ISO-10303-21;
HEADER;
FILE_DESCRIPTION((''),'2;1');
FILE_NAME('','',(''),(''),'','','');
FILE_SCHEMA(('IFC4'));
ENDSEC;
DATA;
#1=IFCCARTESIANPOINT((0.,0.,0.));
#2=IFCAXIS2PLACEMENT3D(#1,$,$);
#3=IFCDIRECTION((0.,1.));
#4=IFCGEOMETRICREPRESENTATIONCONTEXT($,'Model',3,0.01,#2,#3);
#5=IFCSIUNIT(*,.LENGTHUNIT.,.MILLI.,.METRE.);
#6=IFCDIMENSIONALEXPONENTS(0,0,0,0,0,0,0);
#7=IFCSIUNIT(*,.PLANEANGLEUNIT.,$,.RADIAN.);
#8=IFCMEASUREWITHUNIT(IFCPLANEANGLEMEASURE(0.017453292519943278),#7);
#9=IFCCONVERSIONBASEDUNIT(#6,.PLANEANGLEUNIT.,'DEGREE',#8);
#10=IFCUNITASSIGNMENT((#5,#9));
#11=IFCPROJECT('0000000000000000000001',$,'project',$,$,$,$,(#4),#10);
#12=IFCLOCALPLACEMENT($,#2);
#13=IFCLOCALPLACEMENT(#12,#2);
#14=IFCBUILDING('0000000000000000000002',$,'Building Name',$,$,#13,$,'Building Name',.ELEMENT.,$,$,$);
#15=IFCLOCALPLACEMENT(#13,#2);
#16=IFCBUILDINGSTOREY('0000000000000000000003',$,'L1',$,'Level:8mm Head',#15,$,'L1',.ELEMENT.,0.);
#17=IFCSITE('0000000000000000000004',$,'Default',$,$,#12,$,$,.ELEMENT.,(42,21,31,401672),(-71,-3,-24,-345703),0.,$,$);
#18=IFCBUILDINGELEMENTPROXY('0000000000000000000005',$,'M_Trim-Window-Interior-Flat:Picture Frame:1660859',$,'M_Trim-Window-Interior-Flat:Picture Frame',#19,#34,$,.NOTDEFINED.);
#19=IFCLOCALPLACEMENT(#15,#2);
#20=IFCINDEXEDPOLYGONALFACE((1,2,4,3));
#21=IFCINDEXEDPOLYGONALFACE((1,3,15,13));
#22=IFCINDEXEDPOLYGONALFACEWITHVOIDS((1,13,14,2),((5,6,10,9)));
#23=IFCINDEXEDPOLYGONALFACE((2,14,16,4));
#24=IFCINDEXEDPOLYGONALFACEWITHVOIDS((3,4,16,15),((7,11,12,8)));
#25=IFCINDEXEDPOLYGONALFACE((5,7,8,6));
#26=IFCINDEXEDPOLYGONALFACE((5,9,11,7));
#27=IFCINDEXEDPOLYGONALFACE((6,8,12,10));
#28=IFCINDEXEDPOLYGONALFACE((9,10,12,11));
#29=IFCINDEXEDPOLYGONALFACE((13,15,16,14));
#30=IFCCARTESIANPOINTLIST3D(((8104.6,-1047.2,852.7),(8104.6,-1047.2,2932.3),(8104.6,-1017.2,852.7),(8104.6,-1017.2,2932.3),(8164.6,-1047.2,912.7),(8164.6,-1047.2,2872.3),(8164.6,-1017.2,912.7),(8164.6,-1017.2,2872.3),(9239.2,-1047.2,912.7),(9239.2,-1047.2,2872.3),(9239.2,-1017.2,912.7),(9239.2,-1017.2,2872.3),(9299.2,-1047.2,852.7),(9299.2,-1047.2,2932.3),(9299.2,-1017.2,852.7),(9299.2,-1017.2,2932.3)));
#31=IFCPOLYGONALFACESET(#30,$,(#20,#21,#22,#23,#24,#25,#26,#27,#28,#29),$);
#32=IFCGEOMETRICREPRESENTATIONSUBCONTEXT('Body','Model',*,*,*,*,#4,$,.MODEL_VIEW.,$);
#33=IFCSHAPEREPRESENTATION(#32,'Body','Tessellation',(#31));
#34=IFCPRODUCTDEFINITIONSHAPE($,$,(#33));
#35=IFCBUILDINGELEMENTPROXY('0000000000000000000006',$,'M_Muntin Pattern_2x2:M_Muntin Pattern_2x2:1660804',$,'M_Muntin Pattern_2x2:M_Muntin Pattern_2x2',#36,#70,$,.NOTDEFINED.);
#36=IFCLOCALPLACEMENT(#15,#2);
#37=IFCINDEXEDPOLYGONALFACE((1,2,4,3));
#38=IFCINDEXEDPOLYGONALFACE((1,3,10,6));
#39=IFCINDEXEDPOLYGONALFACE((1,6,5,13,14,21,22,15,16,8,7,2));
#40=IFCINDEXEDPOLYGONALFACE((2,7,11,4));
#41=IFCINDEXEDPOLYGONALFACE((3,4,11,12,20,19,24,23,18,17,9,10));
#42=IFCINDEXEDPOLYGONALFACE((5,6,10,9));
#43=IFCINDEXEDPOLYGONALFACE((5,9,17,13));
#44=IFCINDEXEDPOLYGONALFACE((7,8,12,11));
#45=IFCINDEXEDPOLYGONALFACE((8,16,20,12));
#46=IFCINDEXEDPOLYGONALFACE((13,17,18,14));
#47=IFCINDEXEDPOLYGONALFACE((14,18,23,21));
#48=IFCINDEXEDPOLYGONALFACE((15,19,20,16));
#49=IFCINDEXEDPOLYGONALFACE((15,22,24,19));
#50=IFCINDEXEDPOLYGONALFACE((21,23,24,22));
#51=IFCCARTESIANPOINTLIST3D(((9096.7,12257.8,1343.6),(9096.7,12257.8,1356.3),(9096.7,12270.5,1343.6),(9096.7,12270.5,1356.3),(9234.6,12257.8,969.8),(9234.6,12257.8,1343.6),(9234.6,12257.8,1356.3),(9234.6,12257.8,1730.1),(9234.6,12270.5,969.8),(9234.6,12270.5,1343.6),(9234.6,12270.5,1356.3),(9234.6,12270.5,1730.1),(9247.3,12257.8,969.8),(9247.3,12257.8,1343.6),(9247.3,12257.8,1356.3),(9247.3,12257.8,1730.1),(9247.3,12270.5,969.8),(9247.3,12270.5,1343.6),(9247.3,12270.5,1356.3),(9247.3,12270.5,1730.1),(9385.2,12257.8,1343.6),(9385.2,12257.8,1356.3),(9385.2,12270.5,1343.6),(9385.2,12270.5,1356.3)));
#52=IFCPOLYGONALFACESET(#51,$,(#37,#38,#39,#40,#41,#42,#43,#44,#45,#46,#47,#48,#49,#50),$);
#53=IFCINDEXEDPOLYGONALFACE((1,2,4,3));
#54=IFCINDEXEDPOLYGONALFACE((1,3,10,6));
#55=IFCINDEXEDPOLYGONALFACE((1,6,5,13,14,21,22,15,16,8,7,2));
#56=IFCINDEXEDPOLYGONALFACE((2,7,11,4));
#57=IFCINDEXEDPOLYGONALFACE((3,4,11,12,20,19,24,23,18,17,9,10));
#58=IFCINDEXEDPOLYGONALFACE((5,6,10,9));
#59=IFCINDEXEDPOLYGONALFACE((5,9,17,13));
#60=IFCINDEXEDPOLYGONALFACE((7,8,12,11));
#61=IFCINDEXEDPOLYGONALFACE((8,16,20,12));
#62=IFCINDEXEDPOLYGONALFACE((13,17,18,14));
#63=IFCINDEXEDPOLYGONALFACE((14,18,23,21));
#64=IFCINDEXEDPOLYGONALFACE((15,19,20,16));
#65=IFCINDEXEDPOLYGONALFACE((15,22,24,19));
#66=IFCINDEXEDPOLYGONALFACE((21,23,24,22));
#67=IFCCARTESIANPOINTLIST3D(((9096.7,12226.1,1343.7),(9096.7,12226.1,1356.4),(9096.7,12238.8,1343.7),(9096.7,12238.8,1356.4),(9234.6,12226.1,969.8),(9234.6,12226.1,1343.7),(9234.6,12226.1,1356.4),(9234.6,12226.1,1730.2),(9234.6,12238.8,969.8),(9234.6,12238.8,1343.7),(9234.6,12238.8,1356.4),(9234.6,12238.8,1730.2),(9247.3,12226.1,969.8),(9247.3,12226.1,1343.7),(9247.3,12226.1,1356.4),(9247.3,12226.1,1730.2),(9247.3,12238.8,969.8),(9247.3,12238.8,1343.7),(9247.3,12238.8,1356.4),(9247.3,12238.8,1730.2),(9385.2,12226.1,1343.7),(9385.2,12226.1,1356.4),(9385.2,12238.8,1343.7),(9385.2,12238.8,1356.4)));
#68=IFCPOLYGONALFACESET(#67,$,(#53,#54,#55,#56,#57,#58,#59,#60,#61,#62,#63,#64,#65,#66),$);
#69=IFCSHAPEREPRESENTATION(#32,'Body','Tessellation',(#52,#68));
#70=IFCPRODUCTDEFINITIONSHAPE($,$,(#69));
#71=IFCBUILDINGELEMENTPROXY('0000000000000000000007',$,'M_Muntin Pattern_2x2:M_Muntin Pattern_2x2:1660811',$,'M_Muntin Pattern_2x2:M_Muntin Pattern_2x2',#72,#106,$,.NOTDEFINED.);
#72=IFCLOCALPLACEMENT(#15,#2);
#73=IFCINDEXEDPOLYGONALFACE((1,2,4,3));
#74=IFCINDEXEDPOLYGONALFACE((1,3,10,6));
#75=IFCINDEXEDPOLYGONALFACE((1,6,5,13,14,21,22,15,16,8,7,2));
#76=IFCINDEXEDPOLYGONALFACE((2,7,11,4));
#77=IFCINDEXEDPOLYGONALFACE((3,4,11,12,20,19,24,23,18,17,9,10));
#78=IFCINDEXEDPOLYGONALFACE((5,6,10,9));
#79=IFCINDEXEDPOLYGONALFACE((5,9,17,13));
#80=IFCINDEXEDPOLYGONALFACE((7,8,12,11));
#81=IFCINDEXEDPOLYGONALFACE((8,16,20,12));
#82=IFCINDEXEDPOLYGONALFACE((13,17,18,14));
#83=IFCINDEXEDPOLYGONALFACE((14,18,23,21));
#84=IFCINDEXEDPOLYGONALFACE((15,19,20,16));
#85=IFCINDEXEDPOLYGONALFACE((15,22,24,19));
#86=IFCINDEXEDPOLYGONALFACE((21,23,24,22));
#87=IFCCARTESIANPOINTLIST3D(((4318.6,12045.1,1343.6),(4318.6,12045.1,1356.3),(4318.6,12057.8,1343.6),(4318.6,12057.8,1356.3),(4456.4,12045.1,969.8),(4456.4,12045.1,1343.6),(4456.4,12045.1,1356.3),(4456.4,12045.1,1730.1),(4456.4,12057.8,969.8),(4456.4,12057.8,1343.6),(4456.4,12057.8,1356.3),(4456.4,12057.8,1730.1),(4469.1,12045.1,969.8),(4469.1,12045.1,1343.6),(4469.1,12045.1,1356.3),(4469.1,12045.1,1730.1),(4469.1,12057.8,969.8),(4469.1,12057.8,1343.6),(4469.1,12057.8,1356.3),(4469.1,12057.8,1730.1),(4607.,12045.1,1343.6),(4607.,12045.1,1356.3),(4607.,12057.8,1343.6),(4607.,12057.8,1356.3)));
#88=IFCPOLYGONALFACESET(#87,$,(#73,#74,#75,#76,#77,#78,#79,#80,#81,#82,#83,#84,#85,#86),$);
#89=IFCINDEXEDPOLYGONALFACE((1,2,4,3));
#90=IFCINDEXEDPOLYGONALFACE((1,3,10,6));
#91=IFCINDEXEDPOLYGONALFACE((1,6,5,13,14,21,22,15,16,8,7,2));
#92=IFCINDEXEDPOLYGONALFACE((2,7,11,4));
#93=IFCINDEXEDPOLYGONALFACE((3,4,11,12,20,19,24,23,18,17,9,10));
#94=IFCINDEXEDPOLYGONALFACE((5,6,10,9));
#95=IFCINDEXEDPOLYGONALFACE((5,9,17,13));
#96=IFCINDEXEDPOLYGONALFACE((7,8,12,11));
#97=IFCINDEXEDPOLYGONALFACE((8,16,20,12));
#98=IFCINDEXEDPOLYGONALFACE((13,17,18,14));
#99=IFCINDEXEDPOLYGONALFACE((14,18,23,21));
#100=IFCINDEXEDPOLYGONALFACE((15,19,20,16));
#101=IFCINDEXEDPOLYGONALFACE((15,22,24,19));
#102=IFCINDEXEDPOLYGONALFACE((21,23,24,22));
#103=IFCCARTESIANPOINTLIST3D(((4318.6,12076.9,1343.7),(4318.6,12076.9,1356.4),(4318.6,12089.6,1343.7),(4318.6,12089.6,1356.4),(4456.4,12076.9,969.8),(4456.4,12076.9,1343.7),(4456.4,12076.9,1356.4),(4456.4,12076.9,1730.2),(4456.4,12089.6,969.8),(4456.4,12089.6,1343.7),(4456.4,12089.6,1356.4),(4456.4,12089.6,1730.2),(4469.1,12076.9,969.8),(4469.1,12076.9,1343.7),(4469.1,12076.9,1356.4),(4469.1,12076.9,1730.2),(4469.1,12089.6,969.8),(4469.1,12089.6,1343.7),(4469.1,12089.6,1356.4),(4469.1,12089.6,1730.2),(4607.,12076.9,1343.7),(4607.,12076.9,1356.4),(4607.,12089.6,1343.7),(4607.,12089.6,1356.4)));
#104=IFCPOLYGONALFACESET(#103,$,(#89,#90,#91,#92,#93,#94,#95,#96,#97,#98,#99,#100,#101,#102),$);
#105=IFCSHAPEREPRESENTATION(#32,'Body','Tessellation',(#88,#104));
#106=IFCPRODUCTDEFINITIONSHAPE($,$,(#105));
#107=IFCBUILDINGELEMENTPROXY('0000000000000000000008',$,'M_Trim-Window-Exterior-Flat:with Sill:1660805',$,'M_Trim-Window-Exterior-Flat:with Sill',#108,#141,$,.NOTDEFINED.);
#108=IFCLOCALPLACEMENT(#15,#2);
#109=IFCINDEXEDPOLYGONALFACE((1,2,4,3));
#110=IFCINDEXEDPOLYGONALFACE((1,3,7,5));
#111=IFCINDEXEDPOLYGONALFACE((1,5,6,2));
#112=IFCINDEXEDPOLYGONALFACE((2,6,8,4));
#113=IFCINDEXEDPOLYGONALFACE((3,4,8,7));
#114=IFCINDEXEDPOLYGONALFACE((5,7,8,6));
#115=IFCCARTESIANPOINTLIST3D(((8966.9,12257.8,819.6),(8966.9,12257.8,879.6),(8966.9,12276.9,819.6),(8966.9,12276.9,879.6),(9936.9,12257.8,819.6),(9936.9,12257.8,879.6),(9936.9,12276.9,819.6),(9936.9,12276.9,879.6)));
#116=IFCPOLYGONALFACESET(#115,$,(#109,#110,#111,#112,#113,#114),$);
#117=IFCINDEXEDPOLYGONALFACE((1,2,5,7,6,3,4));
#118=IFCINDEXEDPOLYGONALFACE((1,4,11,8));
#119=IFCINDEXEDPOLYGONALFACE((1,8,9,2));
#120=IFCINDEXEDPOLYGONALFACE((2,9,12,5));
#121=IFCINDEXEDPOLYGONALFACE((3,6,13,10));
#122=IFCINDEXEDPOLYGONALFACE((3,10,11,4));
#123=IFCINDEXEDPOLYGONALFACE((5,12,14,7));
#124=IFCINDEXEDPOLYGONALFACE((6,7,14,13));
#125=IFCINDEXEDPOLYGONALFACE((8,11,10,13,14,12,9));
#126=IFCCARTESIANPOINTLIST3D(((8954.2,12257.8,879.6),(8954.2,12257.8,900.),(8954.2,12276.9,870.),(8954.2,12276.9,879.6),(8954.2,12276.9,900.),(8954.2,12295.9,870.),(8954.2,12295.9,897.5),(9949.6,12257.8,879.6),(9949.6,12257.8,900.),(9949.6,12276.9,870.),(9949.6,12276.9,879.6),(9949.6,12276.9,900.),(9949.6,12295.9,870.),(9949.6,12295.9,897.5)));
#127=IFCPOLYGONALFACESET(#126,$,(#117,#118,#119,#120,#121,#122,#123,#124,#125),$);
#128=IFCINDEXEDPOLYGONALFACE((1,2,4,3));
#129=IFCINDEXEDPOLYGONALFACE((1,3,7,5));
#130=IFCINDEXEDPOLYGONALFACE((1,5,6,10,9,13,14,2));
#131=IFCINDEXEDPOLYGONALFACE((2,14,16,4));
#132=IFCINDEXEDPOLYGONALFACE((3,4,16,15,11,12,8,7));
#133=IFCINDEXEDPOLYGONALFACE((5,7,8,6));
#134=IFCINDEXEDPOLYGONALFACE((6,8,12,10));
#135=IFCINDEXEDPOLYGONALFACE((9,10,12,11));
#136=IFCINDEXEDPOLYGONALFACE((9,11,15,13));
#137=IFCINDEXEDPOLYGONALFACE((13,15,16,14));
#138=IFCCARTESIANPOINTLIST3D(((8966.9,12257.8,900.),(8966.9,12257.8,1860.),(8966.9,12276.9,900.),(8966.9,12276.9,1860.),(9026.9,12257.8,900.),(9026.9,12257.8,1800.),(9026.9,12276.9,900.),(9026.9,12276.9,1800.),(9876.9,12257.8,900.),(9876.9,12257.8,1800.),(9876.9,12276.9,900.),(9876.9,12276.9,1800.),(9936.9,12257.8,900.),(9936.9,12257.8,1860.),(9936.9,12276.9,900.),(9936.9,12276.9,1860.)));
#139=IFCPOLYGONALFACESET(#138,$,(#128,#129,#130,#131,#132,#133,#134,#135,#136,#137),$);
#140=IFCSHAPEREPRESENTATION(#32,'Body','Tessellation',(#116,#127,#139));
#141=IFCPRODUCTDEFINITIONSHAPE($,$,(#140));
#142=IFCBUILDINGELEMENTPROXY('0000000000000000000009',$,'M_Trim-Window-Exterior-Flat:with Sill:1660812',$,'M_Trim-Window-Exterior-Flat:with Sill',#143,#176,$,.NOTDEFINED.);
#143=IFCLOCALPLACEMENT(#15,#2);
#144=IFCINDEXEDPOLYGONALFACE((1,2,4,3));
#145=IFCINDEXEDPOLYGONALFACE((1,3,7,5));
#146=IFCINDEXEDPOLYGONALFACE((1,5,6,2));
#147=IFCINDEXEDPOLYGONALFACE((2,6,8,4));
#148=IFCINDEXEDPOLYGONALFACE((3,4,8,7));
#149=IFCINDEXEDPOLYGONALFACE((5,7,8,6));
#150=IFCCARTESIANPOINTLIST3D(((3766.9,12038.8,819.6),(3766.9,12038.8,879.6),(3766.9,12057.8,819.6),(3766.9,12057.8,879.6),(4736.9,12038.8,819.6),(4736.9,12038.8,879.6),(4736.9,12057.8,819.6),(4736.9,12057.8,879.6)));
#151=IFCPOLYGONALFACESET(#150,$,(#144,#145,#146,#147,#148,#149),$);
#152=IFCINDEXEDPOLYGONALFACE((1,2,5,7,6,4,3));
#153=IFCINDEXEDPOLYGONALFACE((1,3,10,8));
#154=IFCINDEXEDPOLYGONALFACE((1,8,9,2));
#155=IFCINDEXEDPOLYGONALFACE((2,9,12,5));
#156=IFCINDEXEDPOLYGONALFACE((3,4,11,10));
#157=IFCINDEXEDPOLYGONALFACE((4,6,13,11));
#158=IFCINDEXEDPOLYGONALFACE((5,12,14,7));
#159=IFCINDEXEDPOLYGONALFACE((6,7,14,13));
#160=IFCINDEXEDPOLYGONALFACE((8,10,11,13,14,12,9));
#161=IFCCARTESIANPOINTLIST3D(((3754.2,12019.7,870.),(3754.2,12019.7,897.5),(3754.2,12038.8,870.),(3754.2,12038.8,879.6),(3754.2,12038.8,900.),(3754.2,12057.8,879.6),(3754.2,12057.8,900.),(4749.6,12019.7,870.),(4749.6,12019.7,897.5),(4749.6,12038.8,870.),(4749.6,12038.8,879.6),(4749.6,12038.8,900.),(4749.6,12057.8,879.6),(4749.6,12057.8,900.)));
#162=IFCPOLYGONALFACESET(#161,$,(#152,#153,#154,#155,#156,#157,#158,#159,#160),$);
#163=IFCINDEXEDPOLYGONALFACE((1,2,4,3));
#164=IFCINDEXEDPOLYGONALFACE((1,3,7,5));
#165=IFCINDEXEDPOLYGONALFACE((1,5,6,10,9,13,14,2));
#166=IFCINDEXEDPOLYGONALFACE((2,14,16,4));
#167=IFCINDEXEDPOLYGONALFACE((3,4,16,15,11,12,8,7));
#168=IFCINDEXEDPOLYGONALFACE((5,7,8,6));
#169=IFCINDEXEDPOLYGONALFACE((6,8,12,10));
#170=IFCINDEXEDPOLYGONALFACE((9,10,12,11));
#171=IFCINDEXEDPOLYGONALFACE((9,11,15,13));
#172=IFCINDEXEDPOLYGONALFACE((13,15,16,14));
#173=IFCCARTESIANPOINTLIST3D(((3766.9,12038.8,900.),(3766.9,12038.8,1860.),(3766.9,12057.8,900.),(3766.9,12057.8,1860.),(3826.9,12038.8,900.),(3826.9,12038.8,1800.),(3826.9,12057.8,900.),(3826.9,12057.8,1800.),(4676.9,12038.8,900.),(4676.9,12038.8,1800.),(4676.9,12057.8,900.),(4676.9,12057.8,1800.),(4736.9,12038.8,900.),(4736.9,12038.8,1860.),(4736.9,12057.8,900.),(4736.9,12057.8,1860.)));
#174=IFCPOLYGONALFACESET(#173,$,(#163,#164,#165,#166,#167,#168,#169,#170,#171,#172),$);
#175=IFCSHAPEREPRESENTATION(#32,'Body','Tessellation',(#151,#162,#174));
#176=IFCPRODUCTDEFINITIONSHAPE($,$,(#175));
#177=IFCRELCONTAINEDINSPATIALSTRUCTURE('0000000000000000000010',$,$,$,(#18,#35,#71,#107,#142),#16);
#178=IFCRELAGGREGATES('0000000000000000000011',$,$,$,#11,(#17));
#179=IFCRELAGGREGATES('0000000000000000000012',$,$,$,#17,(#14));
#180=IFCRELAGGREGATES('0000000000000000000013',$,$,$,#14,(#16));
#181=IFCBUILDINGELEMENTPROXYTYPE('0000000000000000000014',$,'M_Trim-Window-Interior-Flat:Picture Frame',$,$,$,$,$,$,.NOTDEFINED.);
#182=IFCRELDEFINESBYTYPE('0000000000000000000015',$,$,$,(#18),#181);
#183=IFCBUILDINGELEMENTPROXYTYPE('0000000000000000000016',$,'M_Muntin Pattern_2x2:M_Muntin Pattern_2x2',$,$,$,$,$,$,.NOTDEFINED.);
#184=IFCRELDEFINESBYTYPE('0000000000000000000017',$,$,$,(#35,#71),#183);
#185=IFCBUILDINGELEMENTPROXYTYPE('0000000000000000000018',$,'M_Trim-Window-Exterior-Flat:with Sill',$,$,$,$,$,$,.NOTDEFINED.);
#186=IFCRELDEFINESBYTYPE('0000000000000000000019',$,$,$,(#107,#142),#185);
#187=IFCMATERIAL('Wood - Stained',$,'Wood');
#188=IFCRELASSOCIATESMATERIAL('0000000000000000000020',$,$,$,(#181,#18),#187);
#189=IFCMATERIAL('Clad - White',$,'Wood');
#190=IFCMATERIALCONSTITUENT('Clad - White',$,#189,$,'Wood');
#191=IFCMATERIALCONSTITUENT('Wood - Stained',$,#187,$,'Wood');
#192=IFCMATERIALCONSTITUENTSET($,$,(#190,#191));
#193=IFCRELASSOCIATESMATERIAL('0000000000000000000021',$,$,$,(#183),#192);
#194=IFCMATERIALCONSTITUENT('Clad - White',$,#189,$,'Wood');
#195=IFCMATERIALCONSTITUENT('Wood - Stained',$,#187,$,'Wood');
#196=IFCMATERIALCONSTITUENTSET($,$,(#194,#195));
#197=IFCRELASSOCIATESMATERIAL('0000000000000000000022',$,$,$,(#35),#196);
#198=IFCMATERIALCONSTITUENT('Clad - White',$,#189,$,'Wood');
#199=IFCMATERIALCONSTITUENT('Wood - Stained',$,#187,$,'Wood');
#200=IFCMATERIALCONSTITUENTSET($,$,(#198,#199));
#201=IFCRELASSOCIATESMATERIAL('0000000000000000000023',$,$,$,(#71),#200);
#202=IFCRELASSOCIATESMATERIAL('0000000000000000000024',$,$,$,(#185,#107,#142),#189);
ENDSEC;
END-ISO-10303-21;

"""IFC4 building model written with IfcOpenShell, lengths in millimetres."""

from ifc_helpers import new_model, entity, si_unit, converted_unit, direction, frame, origin, place, context, subcontext, project, spatial, indexed_curve, outline, extrude, source, transform, mapped, material, constituent, constituent_set, type_object, type_shapes, element, save


model = new_model("IFC4")

# Units and contexts
model_context = context("Model", 3, precision=0.01, world=origin(), true_north=direction((0.0, 1.0)))
body_context = subcontext(model_context, "Body", "Model", "MODEL_VIEW")
ifc_project = project(units=[si_unit("LENGTHUNIT", "METRE", prefix="MILLI"), converted_unit("PLANEANGLEUNIT", "DEGREE", entity("IfcPlaneAngleMeasure", 0.017453292519943278), si_unit("PLANEANGLEUNIT", "RADIAN"), dimensions=[0, 0, 0, 0, 0, 0, 0])], contexts=[model_context])

# Site, building, storey
site_placement = place(None, origin())
site = spatial("IfcSite", under=ifc_project, at=site_placement, Name="Default", CompositionType="ELEMENT", RefLatitude=(42, 21, 31, 401672), RefLongitude=(-71, -3, -24, -345703), RefElevation=0.0)
building_placement = place(site_placement, origin())
building = spatial("IfcBuilding", under=site, at=building_placement, Name="Building Name", LongName="Building Name", CompositionType="ELEMENT")
storey_placement = place(building_placement, origin())
storey = spatial("IfcBuildingStorey", under=building, at=storey_placement, Name="L1", ObjectType="Level:8mm Head", LongName="L1", CompositionType="ELEMENT", Elevation=0.0)

# Building element proxies
ifc_material_1 = material(Name="Clad - White", Category="Wood")
ifc_material_2 = material(Name="Wood - Stained", Category="Wood")
building_element_proxy_type_1 = type_object("IfcBuildingElementProxyType", Name="M_Trim-Window-Interior-Flat:Picture Frame", PredefinedType="NOTDEFINED", material=ifc_material_2)
shared_shape_1 = source(origin(), body_context, "Body", "SweptSolid", [
    extrude(outline(indexed_curve([(-597.3, -1039.8), (597.3, -1039.8), (597.3, 1039.8), (-597.3, 1039.8), (-597.3, -1039.8)], self_intersect=False), holes=[indexed_curve([(-537.3, -979.8), (-537.3, 979.8), (537.3, 979.8), (537.3, -979.8), (-537.3, -979.8)], self_intersect=False)]), frame((0.0, -992.5, 0.0), z_axis=(0.0, 0.0, 1.0), x_axis=(-1.0, 0.0, 0.0)), (0.0, 0.0, 1.0), 30.0),
])
type_shapes(building_element_proxy_type_1, [shared_shape_1])
for number, where, z_axis, x_axis, name in (
    (1, (8701.9, -1017.2, 2885.0), (0.0, -1.0, 0.0), (1.0, 0.0, 0.0), "M_Trim-Window-Interior-Flat:Picture Frame:1660859"),
):
    element("IfcBuildingElementProxy", number, at=place(storey_placement, frame(where, z_axis=z_axis, x_axis=x_axis)), inside=storey, type_object=building_element_proxy_type_1, material=ifc_material_2, Name=name, ObjectType="M_Trim-Window-Interior-Flat:Picture Frame", PredefinedType="NOTDEFINED", context=body_context, shape_type="MappedRepresentation", body=[
        mapped(shared_shape_1, transform((0.0, 0.0, 0.0), scale=1.0)),
    ])
ifc_constituent_1 = constituent(ifc_material_1, Name="Clad - White", Category="Wood")
ifc_constituent_2 = constituent(ifc_material_2, Name="Wood - Stained", Category="Wood")
ifc_constituent_set_1 = constituent_set(constituents=[ifc_constituent_1, ifc_constituent_2])
ifc_constituent_3 = constituent(ifc_material_1, Name="Clad - White", Category="Wood")
ifc_constituent_4 = constituent(ifc_material_2, Name="Wood - Stained", Category="Wood")
ifc_constituent_set_2 = constituent_set(constituents=[ifc_constituent_3, ifc_constituent_4])
building_element_proxy_type_2 = type_object("IfcBuildingElementProxyType", Name="M_Muntin Pattern_2x2:M_Muntin Pattern_2x2", PredefinedType="NOTDEFINED", material=ifc_constituent_set_2)
shared_shape_2 = source(origin(), body_context, "Body", "SweptSolid", [
    extrude(outline(indexed_curve([(6.4, -6.4), (380.1, -6.4), (380.1, 6.3), (6.4, 6.3), (6.4, 144.2), (-6.3, 144.2), (-6.3, 6.3), (-380.2, 6.3), (-380.2, -6.4), (-6.3, -6.4), (-6.3, -144.2), (6.4, -144.2), (6.4, -6.4)], self_intersect=False)), frame((0.0, 9.5, 380.1), z_axis=(0.0, 1.0, 0.0), x_axis=(0.0, 0.0, 1.0)), (0.0, 0.0, 1.0), 12.7),
    extrude(outline(indexed_curve([(6.4, -6.4), (380.2, -6.4), (380.2, 6.3), (6.4, 6.3), (6.4, 144.2), (-6.3, 144.2), (-6.3, 6.3), (-380.2, 6.3), (-380.2, -6.4), (-6.3, -6.4), (-6.3, -144.2), (6.4, -144.2), (6.4, -6.4)], self_intersect=False)), frame((0.0, -22.2, 380.2), z_axis=(0.0, 1.0, 0.0), x_axis=(0.0, 0.0, 1.0)), (0.0, 0.0, 1.0), 12.7),
])
type_shapes(building_element_proxy_type_2, [shared_shape_2])
proxy_1_placement = place(storey_placement, frame((9241.0, 12248.3, 969.8)))
element("IfcBuildingElementProxy", 2, at=proxy_1_placement, inside=storey, type_object=building_element_proxy_type_2, material=ifc_constituent_set_1, Name="M_Muntin Pattern_2x2:M_Muntin Pattern_2x2:1660804", ObjectType="M_Muntin Pattern_2x2:M_Muntin Pattern_2x2", PredefinedType="NOTDEFINED", context=body_context, shape_type="MappedRepresentation", body=[
    mapped(shared_shape_2, transform((0.0, 0.0, 0.0), scale=1.0)),
])
ifc_constituent_5 = constituent(ifc_material_1, Name="Clad - White", Category="Wood")
ifc_constituent_6 = constituent(ifc_material_2, Name="Wood - Stained", Category="Wood")
ifc_constituent_set_3 = constituent_set(constituents=[ifc_constituent_5, ifc_constituent_6])
proxy_2_placement = place(storey_placement, frame((4462.8, 12067.3, 969.8), z_axis=(0.0, 0.0, 1.0), x_axis=(-1.0, 0.0, 0.0)))
element("IfcBuildingElementProxy", 3, at=proxy_2_placement, inside=storey, type_object=building_element_proxy_type_2, material=ifc_constituent_set_3, Name="M_Muntin Pattern_2x2:M_Muntin Pattern_2x2:1660811", ObjectType="M_Muntin Pattern_2x2:M_Muntin Pattern_2x2", PredefinedType="NOTDEFINED", context=body_context, shape_type="MappedRepresentation", body=[
    mapped(shared_shape_2, transform((0.0, 0.0, 0.0), scale=1.0)),
])
building_element_proxy_type_3 = type_object("IfcBuildingElementProxyType", Name="M_Trim-Window-Exterior-Flat:with Sill", PredefinedType="NOTDEFINED", material=ifc_material_1)
shared_shape_3 = source(origin(), body_context, "Body", "SweptSolid", [
    extrude(outline(indexed_curve([(-485.0, -30.0), (485.0, -30.0), (485.0, 30.0), (-485.0, 30.0), (-485.0, -30.0)], self_intersect=False)), frame((0.0, -950.4, 0.0), z_axis=(0.0, 0.0, 1.0), x_axis=(-1.0, 0.0, 0.0)), (0.0, 0.0, 1.0), 19.0),
    extrude(outline(indexed_curve([(-19.0, -15.2), (0.0, -15.2), (0.0, -5.7), (19.0, -5.7), (19.0, 14.8), (0.0, 14.8), (-19.0, 12.3), (-19.0, -15.2)], self_intersect=False)), frame((-497.7, -914.8, 19.0), z_axis=(1.0, 0.0, 0.0), x_axis=(0.0, 0.0, -1.0)), (0.0, 0.0, 1.0), 995.4),
    extrude(outline(indexed_curve([(-495.0, -485.0), (465.0, -485.0), (465.0, -425.0), (-435.0, -425.0), (-435.0, 425.0), (465.0, 425.0), (465.0, 485.0), (-495.0, 485.0), (-495.0, -485.0)], self_intersect=False)), frame((0.0, -435.0, 0.0), z_axis=(0.0, 0.0, 1.0), x_axis=(0.0, -1.0, 0.0)), (0.0, 0.0, 1.0), 19.0),
])
type_shapes(building_element_proxy_type_3, [shared_shape_3])
for number, where, z_axis, x_axis, name in (
    (4, (9451.9, 12257.8, 1800.0), (0.0, 1.0, 0.0), (-1.0, 0.0, 0.0), "M_Trim-Window-Exterior-Flat:with Sill:1660805"),
    (5, (4251.9, 12057.8, 1800.0), (0.0, -1.0, 0.0), (1.0, 0.0, 0.0), "M_Trim-Window-Exterior-Flat:with Sill:1660812"),
):
    element("IfcBuildingElementProxy", number, at=place(storey_placement, frame(where, z_axis=z_axis, x_axis=x_axis)), inside=storey, type_object=building_element_proxy_type_3, material=ifc_material_1, Name=name, ObjectType="M_Trim-Window-Exterior-Flat:with Sill", PredefinedType="NOTDEFINED", context=body_context, shape_type="MappedRepresentation", body=[
        mapped(shared_shape_3, transform((0.0, 0.0, 0.0), scale=1.0)),
    ])

save(model, "model.ifc")
